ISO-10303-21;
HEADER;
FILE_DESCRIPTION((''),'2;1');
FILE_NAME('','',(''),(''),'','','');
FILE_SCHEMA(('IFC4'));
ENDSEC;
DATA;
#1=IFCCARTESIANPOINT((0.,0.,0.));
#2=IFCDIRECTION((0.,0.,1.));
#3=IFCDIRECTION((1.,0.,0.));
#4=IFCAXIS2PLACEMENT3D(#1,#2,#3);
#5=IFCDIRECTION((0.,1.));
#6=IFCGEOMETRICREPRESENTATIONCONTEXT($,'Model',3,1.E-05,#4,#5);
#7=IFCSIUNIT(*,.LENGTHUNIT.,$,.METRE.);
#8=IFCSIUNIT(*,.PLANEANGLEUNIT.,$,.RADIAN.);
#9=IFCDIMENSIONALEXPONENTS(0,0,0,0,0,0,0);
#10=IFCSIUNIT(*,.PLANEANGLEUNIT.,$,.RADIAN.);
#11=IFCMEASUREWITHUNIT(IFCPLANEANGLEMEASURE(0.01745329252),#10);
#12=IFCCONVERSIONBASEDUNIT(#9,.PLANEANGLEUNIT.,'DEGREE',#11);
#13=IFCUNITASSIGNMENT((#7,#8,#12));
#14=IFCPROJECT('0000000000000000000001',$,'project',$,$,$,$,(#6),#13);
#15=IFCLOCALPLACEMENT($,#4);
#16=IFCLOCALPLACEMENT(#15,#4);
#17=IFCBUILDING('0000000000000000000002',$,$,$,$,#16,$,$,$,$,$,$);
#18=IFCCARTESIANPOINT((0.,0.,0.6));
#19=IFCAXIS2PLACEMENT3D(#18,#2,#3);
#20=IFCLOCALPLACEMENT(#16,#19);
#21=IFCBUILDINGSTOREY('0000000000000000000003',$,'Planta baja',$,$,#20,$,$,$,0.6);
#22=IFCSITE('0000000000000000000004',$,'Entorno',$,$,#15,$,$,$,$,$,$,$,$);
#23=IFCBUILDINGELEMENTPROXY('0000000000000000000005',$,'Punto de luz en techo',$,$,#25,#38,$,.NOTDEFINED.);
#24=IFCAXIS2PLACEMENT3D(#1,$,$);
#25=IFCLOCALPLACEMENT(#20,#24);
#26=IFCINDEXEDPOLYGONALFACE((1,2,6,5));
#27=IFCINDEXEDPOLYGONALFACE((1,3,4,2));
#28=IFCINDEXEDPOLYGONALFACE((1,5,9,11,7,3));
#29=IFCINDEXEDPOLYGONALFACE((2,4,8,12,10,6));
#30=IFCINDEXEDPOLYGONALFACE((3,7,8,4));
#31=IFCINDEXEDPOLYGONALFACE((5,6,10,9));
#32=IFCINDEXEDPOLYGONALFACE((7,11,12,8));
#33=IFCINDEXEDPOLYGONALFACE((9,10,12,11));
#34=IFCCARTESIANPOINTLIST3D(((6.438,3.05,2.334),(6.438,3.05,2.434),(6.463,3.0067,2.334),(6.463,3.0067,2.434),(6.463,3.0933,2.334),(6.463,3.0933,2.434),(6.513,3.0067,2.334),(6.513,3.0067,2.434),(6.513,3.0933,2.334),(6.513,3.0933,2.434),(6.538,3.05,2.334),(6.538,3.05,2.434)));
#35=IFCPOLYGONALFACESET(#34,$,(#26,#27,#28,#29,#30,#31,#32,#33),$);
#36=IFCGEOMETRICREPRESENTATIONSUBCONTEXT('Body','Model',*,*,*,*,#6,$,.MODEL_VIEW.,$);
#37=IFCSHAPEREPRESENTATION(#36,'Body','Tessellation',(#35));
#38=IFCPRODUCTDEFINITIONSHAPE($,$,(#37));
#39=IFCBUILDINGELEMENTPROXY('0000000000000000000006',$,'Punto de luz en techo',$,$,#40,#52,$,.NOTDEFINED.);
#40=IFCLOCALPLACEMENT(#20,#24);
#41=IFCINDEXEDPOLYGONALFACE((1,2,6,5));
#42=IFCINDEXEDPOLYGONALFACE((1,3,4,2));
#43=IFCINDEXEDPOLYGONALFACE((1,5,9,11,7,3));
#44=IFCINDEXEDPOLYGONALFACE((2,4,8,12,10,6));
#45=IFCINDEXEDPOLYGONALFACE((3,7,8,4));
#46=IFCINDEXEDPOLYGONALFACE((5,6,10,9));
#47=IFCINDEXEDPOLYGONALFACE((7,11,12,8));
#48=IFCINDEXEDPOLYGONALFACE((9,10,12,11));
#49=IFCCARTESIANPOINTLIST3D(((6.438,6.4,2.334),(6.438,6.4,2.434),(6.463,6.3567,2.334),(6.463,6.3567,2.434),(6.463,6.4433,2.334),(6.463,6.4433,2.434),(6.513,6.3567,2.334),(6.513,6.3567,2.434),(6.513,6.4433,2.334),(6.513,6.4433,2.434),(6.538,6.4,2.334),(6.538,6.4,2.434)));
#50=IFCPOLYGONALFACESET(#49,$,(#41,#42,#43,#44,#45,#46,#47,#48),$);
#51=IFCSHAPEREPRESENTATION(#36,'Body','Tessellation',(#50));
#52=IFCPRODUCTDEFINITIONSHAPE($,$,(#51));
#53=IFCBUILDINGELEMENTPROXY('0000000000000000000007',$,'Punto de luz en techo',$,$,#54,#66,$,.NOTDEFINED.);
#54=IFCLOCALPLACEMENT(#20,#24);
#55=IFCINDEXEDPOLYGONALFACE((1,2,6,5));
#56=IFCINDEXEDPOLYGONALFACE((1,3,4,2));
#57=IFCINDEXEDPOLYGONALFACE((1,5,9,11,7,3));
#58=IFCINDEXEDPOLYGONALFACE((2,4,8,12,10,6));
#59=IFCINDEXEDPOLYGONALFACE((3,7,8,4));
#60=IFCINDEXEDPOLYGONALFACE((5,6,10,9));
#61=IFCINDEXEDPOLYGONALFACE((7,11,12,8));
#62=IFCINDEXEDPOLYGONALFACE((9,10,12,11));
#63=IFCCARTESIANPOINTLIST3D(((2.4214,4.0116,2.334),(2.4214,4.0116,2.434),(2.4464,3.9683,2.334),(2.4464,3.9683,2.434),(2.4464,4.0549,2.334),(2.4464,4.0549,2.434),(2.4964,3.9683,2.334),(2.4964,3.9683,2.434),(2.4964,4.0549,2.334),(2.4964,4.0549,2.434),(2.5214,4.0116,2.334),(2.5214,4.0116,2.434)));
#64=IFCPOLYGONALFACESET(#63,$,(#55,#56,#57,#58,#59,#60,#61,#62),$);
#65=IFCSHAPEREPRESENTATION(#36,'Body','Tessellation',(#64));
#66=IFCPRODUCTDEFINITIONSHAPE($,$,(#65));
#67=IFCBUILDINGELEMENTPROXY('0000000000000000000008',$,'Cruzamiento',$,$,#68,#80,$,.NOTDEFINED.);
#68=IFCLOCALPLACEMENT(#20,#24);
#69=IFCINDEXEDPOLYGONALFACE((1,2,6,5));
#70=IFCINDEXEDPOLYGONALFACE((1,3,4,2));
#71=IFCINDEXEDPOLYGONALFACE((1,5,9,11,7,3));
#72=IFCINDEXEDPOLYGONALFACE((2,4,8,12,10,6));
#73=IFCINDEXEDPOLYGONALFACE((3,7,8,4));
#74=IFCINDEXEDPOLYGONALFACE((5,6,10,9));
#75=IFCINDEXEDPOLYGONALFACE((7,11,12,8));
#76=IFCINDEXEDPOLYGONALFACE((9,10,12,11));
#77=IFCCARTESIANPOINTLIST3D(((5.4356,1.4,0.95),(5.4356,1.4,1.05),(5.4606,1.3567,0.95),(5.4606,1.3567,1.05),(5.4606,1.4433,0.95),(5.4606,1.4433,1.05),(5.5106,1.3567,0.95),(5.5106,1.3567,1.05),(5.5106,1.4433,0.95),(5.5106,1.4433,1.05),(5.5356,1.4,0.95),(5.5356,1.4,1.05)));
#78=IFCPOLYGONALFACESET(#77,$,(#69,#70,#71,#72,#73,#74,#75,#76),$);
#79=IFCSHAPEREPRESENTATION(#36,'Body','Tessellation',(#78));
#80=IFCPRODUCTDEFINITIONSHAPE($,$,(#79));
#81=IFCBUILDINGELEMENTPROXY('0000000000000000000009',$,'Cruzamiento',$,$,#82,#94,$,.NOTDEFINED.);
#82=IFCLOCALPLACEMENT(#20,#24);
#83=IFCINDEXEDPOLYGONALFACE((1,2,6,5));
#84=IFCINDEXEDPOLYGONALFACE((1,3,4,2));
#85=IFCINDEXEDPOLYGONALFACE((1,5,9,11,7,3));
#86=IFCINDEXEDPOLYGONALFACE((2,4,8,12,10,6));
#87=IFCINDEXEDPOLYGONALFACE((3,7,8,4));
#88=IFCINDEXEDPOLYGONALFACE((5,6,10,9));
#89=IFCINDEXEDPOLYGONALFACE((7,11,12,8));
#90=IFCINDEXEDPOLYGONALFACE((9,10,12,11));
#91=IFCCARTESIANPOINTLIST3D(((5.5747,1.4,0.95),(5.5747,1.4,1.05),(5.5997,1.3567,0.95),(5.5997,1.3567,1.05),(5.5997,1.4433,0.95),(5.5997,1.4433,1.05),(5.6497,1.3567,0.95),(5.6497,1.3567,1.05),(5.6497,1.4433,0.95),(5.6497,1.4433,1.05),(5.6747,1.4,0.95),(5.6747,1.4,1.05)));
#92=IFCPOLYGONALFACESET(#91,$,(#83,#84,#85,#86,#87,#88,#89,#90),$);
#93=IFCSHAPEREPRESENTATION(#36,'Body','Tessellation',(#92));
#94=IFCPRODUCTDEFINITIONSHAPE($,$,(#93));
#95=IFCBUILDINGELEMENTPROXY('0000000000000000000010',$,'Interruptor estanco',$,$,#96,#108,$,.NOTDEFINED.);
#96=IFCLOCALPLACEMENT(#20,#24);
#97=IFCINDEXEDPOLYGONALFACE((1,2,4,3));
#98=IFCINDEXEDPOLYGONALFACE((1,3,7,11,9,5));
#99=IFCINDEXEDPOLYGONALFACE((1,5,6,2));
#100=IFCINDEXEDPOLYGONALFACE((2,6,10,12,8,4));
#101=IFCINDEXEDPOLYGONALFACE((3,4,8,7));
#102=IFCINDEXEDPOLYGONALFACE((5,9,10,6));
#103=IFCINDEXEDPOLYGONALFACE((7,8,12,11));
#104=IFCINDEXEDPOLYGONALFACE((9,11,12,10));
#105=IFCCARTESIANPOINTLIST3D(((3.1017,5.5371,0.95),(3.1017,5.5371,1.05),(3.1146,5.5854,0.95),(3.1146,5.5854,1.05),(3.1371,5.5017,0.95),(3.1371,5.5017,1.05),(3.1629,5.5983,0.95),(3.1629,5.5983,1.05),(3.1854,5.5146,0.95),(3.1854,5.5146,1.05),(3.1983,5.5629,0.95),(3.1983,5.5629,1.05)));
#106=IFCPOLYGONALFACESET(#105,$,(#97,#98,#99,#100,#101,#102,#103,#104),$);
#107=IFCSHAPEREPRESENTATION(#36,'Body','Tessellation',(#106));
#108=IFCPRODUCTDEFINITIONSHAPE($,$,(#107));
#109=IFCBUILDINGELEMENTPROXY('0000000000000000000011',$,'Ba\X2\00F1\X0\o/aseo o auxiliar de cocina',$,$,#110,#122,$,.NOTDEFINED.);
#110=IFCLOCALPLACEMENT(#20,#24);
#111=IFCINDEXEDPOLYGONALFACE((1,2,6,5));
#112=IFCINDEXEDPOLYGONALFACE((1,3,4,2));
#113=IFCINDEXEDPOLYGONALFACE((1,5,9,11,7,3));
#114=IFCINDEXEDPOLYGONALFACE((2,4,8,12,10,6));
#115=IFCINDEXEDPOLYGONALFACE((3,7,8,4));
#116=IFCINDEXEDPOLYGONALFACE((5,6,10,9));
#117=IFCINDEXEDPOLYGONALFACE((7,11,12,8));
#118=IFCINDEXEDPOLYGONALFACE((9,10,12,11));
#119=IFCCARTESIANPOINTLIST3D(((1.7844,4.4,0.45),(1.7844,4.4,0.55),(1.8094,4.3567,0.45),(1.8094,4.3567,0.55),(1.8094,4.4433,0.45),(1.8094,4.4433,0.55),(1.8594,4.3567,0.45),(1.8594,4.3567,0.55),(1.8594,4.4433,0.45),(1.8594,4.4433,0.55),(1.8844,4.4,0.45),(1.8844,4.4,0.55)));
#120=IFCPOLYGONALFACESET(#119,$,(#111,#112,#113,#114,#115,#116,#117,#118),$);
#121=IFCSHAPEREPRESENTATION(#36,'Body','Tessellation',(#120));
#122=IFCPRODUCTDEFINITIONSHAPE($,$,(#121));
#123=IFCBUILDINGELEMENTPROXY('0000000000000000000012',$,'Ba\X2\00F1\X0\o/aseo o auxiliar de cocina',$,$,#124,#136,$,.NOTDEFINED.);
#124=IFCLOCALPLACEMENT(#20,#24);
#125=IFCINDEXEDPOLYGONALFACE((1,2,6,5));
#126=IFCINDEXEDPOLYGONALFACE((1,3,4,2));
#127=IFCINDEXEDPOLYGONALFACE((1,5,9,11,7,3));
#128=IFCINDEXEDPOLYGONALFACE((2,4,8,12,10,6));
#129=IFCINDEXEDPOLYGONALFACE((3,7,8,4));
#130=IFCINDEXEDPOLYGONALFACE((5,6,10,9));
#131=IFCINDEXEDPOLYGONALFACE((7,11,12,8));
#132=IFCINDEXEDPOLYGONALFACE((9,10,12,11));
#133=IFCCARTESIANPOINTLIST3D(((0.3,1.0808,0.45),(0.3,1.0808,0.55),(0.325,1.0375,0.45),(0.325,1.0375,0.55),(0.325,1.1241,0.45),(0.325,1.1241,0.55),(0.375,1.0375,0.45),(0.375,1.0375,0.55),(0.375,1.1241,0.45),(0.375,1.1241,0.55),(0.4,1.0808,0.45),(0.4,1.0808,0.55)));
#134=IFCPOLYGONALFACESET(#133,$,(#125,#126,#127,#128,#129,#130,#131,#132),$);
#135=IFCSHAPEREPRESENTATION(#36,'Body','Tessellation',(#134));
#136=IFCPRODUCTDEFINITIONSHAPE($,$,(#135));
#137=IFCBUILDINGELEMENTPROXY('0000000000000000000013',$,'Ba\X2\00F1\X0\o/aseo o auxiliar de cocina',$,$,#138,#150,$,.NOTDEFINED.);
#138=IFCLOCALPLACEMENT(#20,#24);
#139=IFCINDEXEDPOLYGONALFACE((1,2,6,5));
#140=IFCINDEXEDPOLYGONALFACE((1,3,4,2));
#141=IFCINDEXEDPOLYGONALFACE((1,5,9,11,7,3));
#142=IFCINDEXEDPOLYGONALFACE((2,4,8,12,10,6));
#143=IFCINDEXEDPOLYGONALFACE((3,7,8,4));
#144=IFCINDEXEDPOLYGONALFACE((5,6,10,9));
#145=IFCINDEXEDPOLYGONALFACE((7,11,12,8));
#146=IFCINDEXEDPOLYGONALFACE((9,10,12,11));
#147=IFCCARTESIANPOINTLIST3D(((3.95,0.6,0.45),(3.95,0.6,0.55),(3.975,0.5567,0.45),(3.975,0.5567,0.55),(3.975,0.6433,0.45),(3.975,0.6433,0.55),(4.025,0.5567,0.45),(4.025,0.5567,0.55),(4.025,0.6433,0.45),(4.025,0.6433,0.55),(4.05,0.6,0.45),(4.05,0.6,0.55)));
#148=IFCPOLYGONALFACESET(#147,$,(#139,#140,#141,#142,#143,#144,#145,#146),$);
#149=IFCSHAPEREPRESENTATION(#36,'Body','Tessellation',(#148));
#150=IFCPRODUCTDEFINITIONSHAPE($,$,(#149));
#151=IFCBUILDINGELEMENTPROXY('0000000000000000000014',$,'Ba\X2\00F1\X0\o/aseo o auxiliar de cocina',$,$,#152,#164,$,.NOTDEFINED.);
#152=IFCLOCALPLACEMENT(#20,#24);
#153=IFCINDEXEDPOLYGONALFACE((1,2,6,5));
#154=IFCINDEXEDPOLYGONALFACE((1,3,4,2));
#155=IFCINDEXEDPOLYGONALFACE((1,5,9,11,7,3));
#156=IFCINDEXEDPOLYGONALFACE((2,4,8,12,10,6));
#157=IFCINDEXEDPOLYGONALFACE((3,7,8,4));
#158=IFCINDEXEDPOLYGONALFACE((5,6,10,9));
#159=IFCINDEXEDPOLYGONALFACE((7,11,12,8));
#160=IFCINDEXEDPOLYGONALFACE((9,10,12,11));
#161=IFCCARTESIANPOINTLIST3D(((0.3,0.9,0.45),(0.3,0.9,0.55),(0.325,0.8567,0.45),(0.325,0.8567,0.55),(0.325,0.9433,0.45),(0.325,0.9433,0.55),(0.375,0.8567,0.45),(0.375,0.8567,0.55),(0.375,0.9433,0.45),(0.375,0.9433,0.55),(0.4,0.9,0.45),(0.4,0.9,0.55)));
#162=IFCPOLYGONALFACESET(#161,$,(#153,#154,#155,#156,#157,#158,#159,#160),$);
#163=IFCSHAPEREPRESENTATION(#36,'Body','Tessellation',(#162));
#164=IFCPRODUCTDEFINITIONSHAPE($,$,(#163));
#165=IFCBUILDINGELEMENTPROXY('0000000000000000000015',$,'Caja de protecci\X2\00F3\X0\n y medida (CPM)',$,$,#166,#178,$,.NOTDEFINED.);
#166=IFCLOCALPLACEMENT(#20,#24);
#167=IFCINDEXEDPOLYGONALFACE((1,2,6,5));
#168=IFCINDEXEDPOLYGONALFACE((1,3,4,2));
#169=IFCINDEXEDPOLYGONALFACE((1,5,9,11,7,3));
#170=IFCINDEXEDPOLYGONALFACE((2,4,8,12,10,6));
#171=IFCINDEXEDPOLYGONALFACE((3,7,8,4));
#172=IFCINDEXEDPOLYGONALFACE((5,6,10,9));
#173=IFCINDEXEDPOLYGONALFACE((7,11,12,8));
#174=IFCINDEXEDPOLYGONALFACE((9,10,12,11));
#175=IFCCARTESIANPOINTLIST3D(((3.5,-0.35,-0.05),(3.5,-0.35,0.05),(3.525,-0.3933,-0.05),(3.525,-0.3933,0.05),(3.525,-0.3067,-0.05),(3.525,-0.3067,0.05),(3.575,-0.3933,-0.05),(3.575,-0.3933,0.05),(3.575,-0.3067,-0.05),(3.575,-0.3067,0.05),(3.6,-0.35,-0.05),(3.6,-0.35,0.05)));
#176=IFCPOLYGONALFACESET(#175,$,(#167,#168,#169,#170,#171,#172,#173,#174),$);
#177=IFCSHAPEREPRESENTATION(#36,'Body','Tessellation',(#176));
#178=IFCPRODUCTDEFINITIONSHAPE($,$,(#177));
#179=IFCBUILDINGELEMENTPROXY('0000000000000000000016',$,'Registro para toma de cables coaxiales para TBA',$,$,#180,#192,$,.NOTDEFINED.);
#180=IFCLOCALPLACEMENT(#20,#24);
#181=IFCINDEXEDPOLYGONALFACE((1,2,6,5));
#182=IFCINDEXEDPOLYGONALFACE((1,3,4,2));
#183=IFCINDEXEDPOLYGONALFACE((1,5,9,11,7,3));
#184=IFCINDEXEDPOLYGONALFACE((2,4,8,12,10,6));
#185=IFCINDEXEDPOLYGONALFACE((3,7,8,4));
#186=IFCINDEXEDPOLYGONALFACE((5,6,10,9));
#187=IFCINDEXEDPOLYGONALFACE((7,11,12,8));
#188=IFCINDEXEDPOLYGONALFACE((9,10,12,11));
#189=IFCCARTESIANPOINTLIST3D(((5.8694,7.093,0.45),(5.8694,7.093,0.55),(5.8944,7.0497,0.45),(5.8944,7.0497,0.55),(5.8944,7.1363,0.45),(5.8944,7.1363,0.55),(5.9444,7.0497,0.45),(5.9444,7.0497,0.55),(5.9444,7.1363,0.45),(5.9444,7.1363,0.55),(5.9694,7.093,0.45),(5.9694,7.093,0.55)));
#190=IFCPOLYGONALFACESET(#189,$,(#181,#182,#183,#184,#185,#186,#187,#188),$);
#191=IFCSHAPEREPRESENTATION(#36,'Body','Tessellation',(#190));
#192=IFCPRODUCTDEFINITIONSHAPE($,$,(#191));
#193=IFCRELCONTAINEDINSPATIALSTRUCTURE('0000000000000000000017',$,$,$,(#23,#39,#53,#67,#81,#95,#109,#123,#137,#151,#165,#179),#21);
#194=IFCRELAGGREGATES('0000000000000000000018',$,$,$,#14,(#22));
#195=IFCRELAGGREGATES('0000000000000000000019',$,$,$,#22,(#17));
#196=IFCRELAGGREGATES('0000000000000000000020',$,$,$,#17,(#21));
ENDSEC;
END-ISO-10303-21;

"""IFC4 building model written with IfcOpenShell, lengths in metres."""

from ifc_helpers import new_model, entity, si_unit, converted_unit, direction, frame, origin_with_axes, place, context, subcontext, project, spatial, polyline, outline, extrude, source, transform, mapped, element, save


model = new_model("IFC4")

# Units and contexts
model_context = context("Model", 3, precision=1e-05, world=origin_with_axes(), true_north=direction((0.0, 1.0)))
body_context = subcontext(model_context, "Body", "Model", "MODEL_VIEW")
ifc_project = project(units=[si_unit("LENGTHUNIT", "METRE"), si_unit("PLANEANGLEUNIT", "RADIAN"), converted_unit("PLANEANGLEUNIT", "DEGREE", entity("IfcPlaneAngleMeasure", 0.01745329252), si_unit("PLANEANGLEUNIT", "RADIAN"), dimensions=[0, 0, 0, 0, 0, 0, 0])], contexts=[model_context])

# Site, building, storey
site_placement = place(None, origin_with_axes())
site = spatial("IfcSite", under=ifc_project, at=site_placement, Name="Entorno")
building_placement = place(site_placement, origin_with_axes())
building = spatial("IfcBuilding", under=site, at=building_placement)
storey_placement = place(building_placement, frame((0.0, 0.0, 0.6), z_axis=(0.0, 0.0, 1.0), x_axis=(1.0, 0.0, 0.0)))
storey = spatial("IfcBuildingStorey", under=building, at=storey_placement, Name="Planta baja", Elevation=0.6)

# Building element proxies
shared_shape_1 = source(origin_with_axes(), body_context, "Body", "SolidModel", [
    extrude(outline(polyline([(0.05, 0.0), (0.025, 0.0433), (-0.025, 0.0433), (-0.05, 0.0), (-0.025, -0.0433), (0.025, -0.0433), (0.05, 0.0)])), frame((0.0, 0.0, -0.05), z_axis=(0.0, 0.0, 1.0), x_axis=(1.0, 0.0, 0.0)), (0.0, 0.0, 1.0), 0.1),
])
proxy_1_placement = place(storey_placement, frame((0.0, 0.0, -0.6), z_axis=(0.0, 0.0, 1.0), x_axis=(1.0, 0.0, 0.0)))
element("IfcBuildingElementProxy", 1, at=proxy_1_placement, inside=storey, Name="Punto de luz en techo", PredefinedType="NOTDEFINED", context=body_context, shape_type="Brep", body=[
    mapped(shared_shape_1, transform((6.488, 3.05, 2.984), x_axis=(1.0, 0.0, 0.0), y_axis=(0.0, 1.0, 0.0), z_axis=(0.0, 0.0, 1.0))),
])
proxy_2_placement = place(storey_placement, frame((0.0, 0.0, -0.6), z_axis=(0.0, 0.0, 1.0), x_axis=(1.0, 0.0, 0.0)))
element("IfcBuildingElementProxy", 2, at=proxy_2_placement, inside=storey, Name="Punto de luz en techo", PredefinedType="NOTDEFINED", context=body_context, shape_type="Brep", body=[
    mapped(shared_shape_1, transform((6.488, 6.4, 2.984), x_axis=(1.0, 0.0, 0.0), y_axis=(0.0, 1.0, 0.0), z_axis=(0.0, 0.0, 1.0))),
])
proxy_3_placement = place(storey_placement, frame((0.0, 0.0, -0.6), z_axis=(0.0, 0.0, 1.0), x_axis=(1.0, 0.0, 0.0)))
element("IfcBuildingElementProxy", 3, at=proxy_3_placement, inside=storey, Name="Punto de luz en techo", PredefinedType="NOTDEFINED", context=body_context, shape_type="Brep", body=[
    mapped(shared_shape_1, transform((2.4714, 4.0116, 2.984), x_axis=(1.0, 0.0, 0.0), y_axis=(0.0, 1.0, 0.0), z_axis=(0.0, 0.0, 1.0))),
])
shared_shape_2 = source(origin_with_axes(), body_context, "Body", "SolidModel", [
    extrude(outline(polyline([(0.05, 0.0), (0.025, 0.0433), (-0.025, 0.0433), (-0.05, 0.0), (-0.025, -0.0433), (0.025, -0.0433), (0.05, 0.0)])), frame((0.0, 0.0, -0.05), z_axis=(0.0, 0.0, 1.0), x_axis=(1.0, 0.0, 0.0)), (0.0, 0.0, 1.0), 0.1),
])
proxy_4_placement = place(storey_placement, frame((0.0, 0.0, -0.6), z_axis=(0.0, 0.0, 1.0), x_axis=(1.0, 0.0, 0.0)))
element("IfcBuildingElementProxy", 4, at=proxy_4_placement, inside=storey, Name="Cruzamiento", PredefinedType="NOTDEFINED", context=body_context, shape_type="Brep", body=[
    mapped(shared_shape_2, transform((5.4856, 1.4, 1.6), x_axis=(1.0, 0.0, 0.0), y_axis=(0.0, 1.0, 0.0), z_axis=(0.0, 0.0, 1.0))),
])
proxy_5_placement = place(storey_placement, frame((0.0, 0.0, -0.6), z_axis=(0.0, 0.0, 1.0), x_axis=(1.0, 0.0, 0.0)))
element("IfcBuildingElementProxy", 5, at=proxy_5_placement, inside=storey, Name="Cruzamiento", PredefinedType="NOTDEFINED", context=body_context, shape_type="Brep", body=[
    mapped(shared_shape_2, transform((5.6247, 1.4, 1.6), x_axis=(1.0, 0.0, 0.0), y_axis=(0.0, 1.0, 0.0), z_axis=(0.0, 0.0, 1.0))),
])
shared_shape_3 = source(origin_with_axes(), body_context, "Body", "SolidModel", [
    extrude(outline(polyline([(0.05, 0.0), (0.025, 0.0433), (-0.025, 0.0433), (-0.05, 0.0), (-0.025, -0.0433), (0.025, -0.0433), (0.05, 0.0)])), frame((0.0, 0.0, -0.05), z_axis=(0.0, 0.0, 1.0), x_axis=(1.0, 0.0, 0.0)), (0.0, 0.0, 1.0), 0.1),
])
proxy_6_placement = place(storey_placement, frame((0.0, 0.0, -0.6), z_axis=(0.0, 0.0, 1.0), x_axis=(1.0, 0.0, 0.0)))
element("IfcBuildingElementProxy", 6, at=proxy_6_placement, inside=storey, Name="Interruptor estanco", PredefinedType="NOTDEFINED", context=body_context, shape_type="Brep", body=[
    mapped(shared_shape_3, transform((3.15, 5.55, 1.6), x_axis=(0.707107, -0.707107, 0.0), y_axis=(0.707107, 0.707107, 0.0), z_axis=(0.0, 0.0, 1.0))),
])
shared_shape_4 = source(origin_with_axes(), body_context, "Body", "SolidModel", [
    extrude(outline(polyline([(0.05, 0.0), (0.025, 0.0433), (-0.025, 0.0433), (-0.05, 0.0), (-0.025, -0.0433), (0.025, -0.0433), (0.05, 0.0)])), frame((0.0, 0.0, -0.05), z_axis=(0.0, 0.0, 1.0), x_axis=(1.0, 0.0, 0.0)), (0.0, 0.0, 1.0), 0.1),
])
proxy_7_placement = place(storey_placement, frame((0.0, 0.0, -0.6), z_axis=(0.0, 0.0, 1.0), x_axis=(1.0, 0.0, 0.0)))
element("IfcBuildingElementProxy", 7, at=proxy_7_placement, inside=storey, Name="Baño/aseo o auxiliar de cocina", PredefinedType="NOTDEFINED", context=body_context, shape_type="Brep", body=[
    mapped(shared_shape_4, transform((1.8344, 4.4, 1.1), x_axis=(-1.0, 0.0, 0.0), y_axis=(0.0, -1.0, 0.0), z_axis=(0.0, 0.0, 1.0))),
])
proxy_8_placement = place(storey_placement, frame((0.0, 0.0, -0.6), z_axis=(0.0, 0.0, 1.0), x_axis=(1.0, 0.0, 0.0)))
element("IfcBuildingElementProxy", 8, at=proxy_8_placement, inside=storey, Name="Baño/aseo o auxiliar de cocina", PredefinedType="NOTDEFINED", context=body_context, shape_type="Brep", body=[
    mapped(shared_shape_4, transform((0.35, 1.0808, 1.1), x_axis=(1.0, 0.0, 0.0), y_axis=(0.0, 1.0, 0.0), z_axis=(0.0, 0.0, 1.0))),
])
proxy_9_placement = place(storey_placement, frame((0.0, 0.0, -0.6), z_axis=(0.0, 0.0, 1.0), x_axis=(1.0, 0.0, 0.0)))
element("IfcBuildingElementProxy", 9, at=proxy_9_placement, inside=storey, Name="Baño/aseo o auxiliar de cocina", PredefinedType="NOTDEFINED", context=body_context, shape_type="Brep", body=[
    mapped(shared_shape_4, transform((4.0, 0.6, 1.1), x_axis=(-1.0, 0.0, 0.0), y_axis=(0.0, -1.0, 0.0), z_axis=(0.0, 0.0, 1.0))),
])
proxy_10_placement = place(storey_placement, frame((0.0, 0.0, -0.6), z_axis=(0.0, 0.0, 1.0), x_axis=(1.0, 0.0, 0.0)))
element("IfcBuildingElementProxy", 10, at=proxy_10_placement, inside=storey, Name="Baño/aseo o auxiliar de cocina", PredefinedType="NOTDEFINED", context=body_context, shape_type="Brep", body=[
    mapped(shared_shape_4, transform((0.35, 0.9, 1.1), x_axis=(1.0, 0.0, 0.0), y_axis=(0.0, 1.0, 0.0), z_axis=(0.0, 0.0, 1.0))),
])
shared_shape_5 = source(origin_with_axes(), body_context, "Body", "SolidModel", [
    extrude(outline(polyline([(0.05, 0.0), (0.025, 0.0433), (-0.025, 0.0433), (-0.05, 0.0), (-0.025, -0.0433), (0.025, -0.0433), (0.05, 0.0)])), frame((0.0, 0.0, -0.05), z_axis=(0.0, 0.0, 1.0), x_axis=(1.0, 0.0, 0.0)), (0.0, 0.0, 1.0), 0.1),
])
proxy_11_placement = place(storey_placement, frame((0.0, 0.0, -0.6), z_axis=(0.0, 0.0, 1.0), x_axis=(1.0, 0.0, 0.0)))
element("IfcBuildingElementProxy", 11, at=proxy_11_placement, inside=storey, Name="Caja de protección y medida (CPM)", PredefinedType="NOTDEFINED", context=body_context, shape_type="Brep", body=[
    mapped(shared_shape_5, transform((3.55, -0.35, 0.6), x_axis=(1.0, 0.0, 0.0), y_axis=(0.0, 1.0, 0.0), z_axis=(0.0, 0.0, 1.0))),
])
shared_shape_6 = source(origin_with_axes(), body_context, "Body", "SolidModel", [
    extrude(outline(polyline([(0.05, 0.0), (0.025, 0.0433), (-0.025, 0.0433), (-0.05, 0.0), (-0.025, -0.0433), (0.025, -0.0433), (0.05, 0.0)])), frame((0.0, 0.0, -0.05), z_axis=(0.0, 0.0, 1.0), x_axis=(1.0, 0.0, 0.0)), (0.0, 0.0, 1.0), 0.1),
])
proxy_12_placement = place(storey_placement, frame((0.0, 0.0, -0.6), z_axis=(0.0, 0.0, 1.0), x_axis=(1.0, 0.0, 0.0)))
element("IfcBuildingElementProxy", 12, at=proxy_12_placement, inside=storey, Name="Registro para toma de cables coaxiales para TBA", PredefinedType="NOTDEFINED", context=body_context, shape_type="Brep", body=[
    mapped(shared_shape_6, transform((5.9194, 7.093, 1.1), x_axis=(1.0, 0.0, 0.0), y_axis=(0.0, 1.0, 0.0), z_axis=(0.0, 0.0, 1.0))),
])

save(model, "model.ifc")
